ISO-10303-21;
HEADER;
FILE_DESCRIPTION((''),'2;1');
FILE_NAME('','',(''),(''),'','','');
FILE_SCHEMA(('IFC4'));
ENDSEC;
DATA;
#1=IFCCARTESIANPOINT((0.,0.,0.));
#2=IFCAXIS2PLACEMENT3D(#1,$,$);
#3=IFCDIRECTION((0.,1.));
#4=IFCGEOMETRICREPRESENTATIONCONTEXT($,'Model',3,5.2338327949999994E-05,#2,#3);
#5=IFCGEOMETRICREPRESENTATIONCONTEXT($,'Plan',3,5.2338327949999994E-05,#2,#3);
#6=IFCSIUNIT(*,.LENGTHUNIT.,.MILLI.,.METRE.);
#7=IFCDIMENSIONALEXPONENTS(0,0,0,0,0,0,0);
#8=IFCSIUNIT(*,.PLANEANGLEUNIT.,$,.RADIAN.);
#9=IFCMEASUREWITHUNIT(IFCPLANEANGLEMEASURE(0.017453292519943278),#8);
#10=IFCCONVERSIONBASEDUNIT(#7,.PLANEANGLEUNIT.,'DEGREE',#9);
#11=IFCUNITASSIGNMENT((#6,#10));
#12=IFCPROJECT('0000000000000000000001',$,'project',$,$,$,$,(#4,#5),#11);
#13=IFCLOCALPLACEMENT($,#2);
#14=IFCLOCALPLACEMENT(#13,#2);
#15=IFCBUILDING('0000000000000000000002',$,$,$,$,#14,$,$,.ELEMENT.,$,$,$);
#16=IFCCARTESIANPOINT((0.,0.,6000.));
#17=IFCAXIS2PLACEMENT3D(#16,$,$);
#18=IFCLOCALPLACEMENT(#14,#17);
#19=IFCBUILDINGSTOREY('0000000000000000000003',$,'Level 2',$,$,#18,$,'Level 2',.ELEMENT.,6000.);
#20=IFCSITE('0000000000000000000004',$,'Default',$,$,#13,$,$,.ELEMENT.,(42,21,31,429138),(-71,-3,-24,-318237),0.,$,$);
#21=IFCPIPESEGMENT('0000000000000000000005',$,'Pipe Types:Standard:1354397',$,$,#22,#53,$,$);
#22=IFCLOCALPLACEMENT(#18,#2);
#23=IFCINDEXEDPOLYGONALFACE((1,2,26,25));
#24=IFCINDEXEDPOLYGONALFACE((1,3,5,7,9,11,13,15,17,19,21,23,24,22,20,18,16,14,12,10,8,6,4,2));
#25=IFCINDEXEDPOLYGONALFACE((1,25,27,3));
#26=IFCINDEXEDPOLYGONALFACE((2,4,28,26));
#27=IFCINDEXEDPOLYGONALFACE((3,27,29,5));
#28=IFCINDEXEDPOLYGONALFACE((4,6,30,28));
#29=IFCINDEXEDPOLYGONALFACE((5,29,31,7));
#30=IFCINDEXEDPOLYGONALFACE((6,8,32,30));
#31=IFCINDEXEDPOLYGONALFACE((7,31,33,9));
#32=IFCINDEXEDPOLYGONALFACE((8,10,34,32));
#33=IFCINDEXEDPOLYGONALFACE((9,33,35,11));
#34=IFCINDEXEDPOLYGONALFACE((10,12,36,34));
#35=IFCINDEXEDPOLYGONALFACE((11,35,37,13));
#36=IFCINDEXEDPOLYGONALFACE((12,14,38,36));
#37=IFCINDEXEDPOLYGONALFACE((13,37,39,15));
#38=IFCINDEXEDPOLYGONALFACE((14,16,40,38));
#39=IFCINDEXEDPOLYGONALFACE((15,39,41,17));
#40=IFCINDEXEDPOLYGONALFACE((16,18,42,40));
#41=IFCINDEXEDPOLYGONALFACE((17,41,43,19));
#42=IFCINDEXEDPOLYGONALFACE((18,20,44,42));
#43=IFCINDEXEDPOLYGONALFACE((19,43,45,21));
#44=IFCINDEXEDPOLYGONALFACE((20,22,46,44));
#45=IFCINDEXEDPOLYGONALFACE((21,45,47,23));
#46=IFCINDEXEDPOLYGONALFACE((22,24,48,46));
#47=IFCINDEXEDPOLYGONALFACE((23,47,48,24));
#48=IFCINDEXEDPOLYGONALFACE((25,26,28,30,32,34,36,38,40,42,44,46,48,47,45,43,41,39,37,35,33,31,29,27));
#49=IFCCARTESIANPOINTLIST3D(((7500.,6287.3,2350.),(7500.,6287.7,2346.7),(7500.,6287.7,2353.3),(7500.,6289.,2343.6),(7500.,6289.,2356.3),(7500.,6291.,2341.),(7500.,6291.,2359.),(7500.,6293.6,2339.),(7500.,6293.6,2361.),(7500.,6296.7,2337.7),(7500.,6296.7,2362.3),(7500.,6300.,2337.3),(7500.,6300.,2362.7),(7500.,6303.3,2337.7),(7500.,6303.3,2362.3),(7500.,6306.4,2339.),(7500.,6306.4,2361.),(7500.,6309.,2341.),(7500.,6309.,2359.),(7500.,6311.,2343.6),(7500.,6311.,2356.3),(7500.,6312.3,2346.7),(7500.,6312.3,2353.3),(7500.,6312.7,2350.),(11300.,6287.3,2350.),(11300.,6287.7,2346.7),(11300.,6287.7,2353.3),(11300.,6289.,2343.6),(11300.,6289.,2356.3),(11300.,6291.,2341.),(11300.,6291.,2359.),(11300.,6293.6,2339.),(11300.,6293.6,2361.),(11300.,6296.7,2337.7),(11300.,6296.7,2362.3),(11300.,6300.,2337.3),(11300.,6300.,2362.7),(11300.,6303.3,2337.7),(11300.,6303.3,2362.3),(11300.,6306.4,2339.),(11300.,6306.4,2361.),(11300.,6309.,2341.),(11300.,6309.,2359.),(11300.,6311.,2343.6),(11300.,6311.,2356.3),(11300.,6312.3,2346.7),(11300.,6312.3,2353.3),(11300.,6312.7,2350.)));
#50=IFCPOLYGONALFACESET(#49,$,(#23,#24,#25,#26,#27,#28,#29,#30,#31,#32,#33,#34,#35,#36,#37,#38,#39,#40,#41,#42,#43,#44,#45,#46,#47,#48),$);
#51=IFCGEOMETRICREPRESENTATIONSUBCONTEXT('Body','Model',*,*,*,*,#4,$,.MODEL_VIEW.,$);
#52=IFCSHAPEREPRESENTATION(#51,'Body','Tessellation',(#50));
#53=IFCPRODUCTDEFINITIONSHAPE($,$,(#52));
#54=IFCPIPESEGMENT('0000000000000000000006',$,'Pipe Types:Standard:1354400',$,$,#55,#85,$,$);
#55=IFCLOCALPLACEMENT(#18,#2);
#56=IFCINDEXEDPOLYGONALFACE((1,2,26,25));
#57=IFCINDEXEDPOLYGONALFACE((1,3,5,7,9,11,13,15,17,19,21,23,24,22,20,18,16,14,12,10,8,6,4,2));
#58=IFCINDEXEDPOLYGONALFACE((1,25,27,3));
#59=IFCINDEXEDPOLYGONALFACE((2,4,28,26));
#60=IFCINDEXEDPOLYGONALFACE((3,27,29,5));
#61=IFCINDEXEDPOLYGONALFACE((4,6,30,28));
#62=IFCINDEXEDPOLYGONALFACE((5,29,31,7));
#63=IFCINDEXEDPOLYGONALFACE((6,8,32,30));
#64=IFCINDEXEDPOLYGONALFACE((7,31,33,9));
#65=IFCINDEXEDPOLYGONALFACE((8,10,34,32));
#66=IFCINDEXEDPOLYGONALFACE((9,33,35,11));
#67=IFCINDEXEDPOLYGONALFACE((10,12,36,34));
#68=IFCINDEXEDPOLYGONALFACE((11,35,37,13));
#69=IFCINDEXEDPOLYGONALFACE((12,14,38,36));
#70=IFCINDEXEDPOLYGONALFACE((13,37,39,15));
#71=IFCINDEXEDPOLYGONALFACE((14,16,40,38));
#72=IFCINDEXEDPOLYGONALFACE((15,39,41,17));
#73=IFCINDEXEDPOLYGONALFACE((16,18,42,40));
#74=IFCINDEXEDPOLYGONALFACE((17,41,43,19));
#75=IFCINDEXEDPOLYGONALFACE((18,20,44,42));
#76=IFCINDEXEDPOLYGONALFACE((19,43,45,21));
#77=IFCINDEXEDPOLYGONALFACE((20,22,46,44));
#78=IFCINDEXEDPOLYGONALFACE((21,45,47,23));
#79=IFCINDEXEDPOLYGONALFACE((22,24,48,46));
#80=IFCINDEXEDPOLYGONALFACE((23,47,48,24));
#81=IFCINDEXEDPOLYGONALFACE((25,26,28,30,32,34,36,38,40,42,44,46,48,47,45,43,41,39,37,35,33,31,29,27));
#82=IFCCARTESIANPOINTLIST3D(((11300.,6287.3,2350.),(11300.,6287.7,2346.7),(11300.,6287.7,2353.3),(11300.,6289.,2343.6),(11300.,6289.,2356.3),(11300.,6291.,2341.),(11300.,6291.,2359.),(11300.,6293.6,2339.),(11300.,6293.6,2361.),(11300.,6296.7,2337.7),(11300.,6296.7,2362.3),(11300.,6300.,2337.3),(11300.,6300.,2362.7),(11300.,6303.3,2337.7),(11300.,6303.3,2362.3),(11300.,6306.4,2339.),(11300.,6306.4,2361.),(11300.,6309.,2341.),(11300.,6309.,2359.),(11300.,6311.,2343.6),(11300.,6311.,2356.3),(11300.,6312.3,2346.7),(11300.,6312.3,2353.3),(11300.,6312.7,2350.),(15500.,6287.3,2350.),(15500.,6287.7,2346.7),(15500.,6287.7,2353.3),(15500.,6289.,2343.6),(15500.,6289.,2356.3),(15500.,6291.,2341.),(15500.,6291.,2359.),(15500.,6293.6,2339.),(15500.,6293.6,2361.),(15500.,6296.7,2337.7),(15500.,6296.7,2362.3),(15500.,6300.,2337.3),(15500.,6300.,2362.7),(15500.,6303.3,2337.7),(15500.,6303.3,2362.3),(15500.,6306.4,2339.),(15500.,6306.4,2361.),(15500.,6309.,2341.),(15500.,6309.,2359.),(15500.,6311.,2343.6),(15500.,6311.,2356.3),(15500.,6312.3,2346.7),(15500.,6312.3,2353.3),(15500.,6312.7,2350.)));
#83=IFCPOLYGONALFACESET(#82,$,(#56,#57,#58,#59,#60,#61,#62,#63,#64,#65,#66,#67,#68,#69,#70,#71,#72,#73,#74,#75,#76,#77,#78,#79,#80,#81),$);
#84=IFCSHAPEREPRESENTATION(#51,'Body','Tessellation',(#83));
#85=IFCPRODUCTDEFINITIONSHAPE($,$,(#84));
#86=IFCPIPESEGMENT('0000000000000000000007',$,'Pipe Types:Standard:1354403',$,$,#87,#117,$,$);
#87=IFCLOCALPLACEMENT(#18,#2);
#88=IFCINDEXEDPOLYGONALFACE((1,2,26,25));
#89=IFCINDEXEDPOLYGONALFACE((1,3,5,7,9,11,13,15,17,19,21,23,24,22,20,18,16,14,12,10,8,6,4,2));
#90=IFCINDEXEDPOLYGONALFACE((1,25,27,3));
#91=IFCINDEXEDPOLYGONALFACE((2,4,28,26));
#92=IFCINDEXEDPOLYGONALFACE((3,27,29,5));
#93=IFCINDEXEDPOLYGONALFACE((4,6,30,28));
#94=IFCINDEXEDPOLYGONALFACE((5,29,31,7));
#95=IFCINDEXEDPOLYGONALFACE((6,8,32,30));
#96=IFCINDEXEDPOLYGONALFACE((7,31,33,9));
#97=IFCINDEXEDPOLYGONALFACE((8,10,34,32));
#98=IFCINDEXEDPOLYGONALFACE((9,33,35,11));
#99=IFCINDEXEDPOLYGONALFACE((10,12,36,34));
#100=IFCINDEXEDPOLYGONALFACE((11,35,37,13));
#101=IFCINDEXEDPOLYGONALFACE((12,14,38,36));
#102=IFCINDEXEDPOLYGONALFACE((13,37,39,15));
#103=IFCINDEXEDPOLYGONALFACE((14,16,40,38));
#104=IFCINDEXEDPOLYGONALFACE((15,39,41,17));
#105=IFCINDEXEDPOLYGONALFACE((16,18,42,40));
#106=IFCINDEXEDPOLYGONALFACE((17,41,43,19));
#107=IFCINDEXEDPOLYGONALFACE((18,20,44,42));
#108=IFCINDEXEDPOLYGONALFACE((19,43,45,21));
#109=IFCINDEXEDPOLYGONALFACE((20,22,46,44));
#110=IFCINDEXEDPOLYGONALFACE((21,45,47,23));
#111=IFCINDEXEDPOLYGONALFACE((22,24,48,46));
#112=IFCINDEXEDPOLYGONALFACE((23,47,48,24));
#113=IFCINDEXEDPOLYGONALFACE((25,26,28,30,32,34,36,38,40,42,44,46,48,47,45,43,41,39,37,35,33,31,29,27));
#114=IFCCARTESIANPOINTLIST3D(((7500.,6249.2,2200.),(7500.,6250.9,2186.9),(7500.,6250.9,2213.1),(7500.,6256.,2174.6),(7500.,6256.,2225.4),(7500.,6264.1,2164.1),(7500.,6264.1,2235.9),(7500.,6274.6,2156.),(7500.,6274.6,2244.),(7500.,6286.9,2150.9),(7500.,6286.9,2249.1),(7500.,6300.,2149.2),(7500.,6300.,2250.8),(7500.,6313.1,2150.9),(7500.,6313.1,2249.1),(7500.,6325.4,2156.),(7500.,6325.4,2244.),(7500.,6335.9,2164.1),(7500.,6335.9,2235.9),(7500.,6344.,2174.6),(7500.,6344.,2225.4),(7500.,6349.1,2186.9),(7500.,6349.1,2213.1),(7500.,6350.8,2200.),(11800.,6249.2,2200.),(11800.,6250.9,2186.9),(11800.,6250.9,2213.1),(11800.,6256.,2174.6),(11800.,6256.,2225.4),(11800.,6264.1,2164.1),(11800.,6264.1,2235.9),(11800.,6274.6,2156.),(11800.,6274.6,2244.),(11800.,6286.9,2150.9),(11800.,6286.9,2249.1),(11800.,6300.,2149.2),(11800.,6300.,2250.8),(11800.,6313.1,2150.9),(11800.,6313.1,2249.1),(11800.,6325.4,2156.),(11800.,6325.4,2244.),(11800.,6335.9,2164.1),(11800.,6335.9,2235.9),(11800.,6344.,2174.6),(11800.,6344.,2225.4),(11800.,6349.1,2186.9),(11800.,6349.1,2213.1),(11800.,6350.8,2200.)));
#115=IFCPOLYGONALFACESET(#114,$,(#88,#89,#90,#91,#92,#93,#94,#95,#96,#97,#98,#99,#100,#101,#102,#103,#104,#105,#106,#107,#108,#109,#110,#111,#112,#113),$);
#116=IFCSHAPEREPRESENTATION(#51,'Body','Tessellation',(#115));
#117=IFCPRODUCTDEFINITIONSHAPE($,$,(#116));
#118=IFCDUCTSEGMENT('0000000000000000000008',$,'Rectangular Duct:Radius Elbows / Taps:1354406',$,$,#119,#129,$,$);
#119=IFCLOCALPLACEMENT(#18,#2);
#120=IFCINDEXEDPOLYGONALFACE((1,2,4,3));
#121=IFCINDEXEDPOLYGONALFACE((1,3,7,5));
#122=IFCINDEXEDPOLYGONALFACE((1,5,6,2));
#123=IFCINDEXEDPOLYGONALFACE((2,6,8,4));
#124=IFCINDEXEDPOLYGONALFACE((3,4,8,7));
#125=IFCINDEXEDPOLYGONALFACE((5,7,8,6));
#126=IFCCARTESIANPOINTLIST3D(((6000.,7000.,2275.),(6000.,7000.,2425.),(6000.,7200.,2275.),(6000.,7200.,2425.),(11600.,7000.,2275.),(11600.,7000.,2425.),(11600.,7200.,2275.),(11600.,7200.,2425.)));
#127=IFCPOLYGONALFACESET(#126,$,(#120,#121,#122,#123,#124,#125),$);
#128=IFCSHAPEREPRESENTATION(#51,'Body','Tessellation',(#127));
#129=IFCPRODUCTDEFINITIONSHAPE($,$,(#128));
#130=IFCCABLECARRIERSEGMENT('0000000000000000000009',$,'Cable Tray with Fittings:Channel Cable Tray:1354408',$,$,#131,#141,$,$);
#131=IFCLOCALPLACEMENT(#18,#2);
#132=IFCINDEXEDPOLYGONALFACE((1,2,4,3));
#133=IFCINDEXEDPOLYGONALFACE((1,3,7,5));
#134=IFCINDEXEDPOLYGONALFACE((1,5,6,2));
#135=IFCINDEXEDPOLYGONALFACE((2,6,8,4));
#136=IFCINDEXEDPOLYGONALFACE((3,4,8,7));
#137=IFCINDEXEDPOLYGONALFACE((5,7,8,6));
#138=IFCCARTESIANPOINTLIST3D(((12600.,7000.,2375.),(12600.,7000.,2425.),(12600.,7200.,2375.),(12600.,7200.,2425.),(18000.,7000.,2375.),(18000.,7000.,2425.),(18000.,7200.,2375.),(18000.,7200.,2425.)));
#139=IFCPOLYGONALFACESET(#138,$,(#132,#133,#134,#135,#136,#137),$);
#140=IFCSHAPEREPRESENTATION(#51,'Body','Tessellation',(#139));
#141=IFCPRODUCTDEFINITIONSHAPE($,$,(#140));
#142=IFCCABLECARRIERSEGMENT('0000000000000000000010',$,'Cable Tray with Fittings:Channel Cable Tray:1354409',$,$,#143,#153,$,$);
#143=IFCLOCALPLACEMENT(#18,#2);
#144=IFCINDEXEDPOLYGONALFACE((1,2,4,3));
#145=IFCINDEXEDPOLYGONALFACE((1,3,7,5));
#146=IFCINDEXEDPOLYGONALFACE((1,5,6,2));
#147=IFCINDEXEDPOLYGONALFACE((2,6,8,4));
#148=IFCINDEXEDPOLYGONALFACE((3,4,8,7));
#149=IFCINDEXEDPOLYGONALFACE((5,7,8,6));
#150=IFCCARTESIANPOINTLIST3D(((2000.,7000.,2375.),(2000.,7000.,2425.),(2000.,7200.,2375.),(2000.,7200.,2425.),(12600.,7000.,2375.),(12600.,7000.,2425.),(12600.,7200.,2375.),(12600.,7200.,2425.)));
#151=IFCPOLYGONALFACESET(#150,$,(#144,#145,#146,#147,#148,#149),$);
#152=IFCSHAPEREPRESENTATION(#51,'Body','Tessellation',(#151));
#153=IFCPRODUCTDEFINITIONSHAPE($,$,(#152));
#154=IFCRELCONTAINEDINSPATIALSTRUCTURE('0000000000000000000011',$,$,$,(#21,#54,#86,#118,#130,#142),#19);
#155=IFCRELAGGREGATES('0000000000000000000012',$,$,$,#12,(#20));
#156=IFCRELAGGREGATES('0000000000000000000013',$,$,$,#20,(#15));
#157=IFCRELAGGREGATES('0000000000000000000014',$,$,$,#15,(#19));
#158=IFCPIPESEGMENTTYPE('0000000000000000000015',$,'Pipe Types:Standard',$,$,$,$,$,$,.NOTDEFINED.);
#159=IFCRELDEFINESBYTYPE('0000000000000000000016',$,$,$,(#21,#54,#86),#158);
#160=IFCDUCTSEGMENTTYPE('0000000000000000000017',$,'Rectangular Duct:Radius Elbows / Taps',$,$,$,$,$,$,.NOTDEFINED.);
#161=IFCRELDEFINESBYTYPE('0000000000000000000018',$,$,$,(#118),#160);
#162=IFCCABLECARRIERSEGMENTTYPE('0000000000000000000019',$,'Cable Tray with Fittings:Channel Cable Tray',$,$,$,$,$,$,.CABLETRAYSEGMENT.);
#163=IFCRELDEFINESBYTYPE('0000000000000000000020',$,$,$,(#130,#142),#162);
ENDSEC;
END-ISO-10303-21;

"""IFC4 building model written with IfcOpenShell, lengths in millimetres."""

from ifc_helpers import new_model, entity, si_unit, converted_unit, direction, frame, origin, place, context, subcontext, project, spatial, arc, indexed_curve, outline, extrude, type_object, element, save


model = new_model("IFC4")

# Units and contexts
model_context = context("Model", 3, precision=5.2338327949999994e-05, world=origin(), true_north=direction((0.0, 1.0)))
plan_context = context("Plan", 3, precision=5.2338327949999994e-05, world=origin(), true_north=direction((0.0, 1.0)))
body_context = subcontext(model_context, "Body", "Model", "MODEL_VIEW")
ifc_project = project(units=[si_unit("LENGTHUNIT", "METRE", prefix="MILLI"), converted_unit("PLANEANGLEUNIT", "DEGREE", entity("IfcPlaneAngleMeasure", 0.017453292519943278), si_unit("PLANEANGLEUNIT", "RADIAN"), dimensions=[0, 0, 0, 0, 0, 0, 0])], contexts=[model_context, plan_context])

# Site, building, storey
site_placement = place(None, origin())
site = spatial("IfcSite", under=ifc_project, at=site_placement, Name="Default", CompositionType="ELEMENT", RefLatitude=(42, 21, 31, 429138), RefLongitude=(-71, -3, -24, -318237), RefElevation=0.0)
building_placement = place(site_placement, origin())
building = spatial("IfcBuilding", under=site, at=building_placement, CompositionType="ELEMENT")
storey_placement = place(building_placement, frame((0.0, 0.0, 6000.0)))
storey = spatial("IfcBuildingStorey", under=building, at=storey_placement, Name="Level 2", LongName="Level 2", CompositionType="ELEMENT", Elevation=6000.0)

# Pipe segments
pipe_segment_type = type_object("IfcPipeSegmentType", Name="Pipe Types:Standard", PredefinedType="NOTDEFINED")
pipe_segment_1_placement = place(storey_placement, origin())
element("IfcPipeSegment", 1, at=pipe_segment_1_placement, inside=storey, type_object=pipe_segment_type, Name="Pipe Types:Standard:1354397", context=body_context, shape_type="SweptSolid", body=[
    extrude(outline(indexed_curve([(12.7, 0.0), (9.0, 9.0), (0.0, 12.7), (-9.0, 9.0), (-12.7, 0.0), (-9.0, -9.0), (0.0, -12.7), (9.0, -9.0)], segments=[arc(1, 2, 3), arc(3, 4, 5), arc(5, 6, 7), arc(7, 8, 1)], self_intersect=False)), frame((7500.0, 6300.0, 2350.0), z_axis=(1.0, 0.0, 0.0), x_axis=(0.0, 1.0, 0.0)), (0.0, 0.0, 1.0), 3800.0),
])
pipe_segment_2_placement = place(storey_placement, origin())
element("IfcPipeSegment", 2, at=pipe_segment_2_placement, inside=storey, type_object=pipe_segment_type, Name="Pipe Types:Standard:1354400", context=body_context, shape_type="SweptSolid", body=[
    extrude(outline(indexed_curve([(12.7, 0.0), (9.0, 9.0), (0.0, 12.7), (-9.0, 9.0), (-12.7, 0.0), (-9.0, -9.0), (0.0, -12.7), (9.0, -9.0)], segments=[arc(1, 2, 3), arc(3, 4, 5), arc(5, 6, 7), arc(7, 8, 1)], self_intersect=False)), frame((11300.0, 6300.0, 2350.0), z_axis=(1.0, 0.0, 0.0), x_axis=(0.0, -1.0, 0.0)), (0.0, 0.0, 1.0), 4200.0),
])
pipe_segment_3_placement = place(storey_placement, origin())
element("IfcPipeSegment", 3, at=pipe_segment_3_placement, inside=storey, type_object=pipe_segment_type, Name="Pipe Types:Standard:1354403", context=body_context, shape_type="SweptSolid", body=[
    extrude(outline(indexed_curve([(50.8, 0.0), (35.9, 35.9), (0.0, 50.8), (-35.9, 35.9), (-50.8, 0.0), (-35.9, -35.9), (0.0, -50.8), (35.9, -35.9)], segments=[arc(1, 2, 3), arc(3, 4, 5), arc(5, 6, 7), arc(7, 8, 1)], self_intersect=False)), frame((7500.0, 6300.0, 2200.0), z_axis=(1.0, 0.0, 0.0), x_axis=(0.0, 1.0, 0.0)), (0.0, 0.0, 1.0), 4300.0),
])

# Duct segment
duct_segment_type = type_object("IfcDuctSegmentType", Name="Rectangular Duct:Radius Elbows / Taps", PredefinedType="NOTDEFINED")
duct_segment_placement = place(storey_placement, origin())
element("IfcDuctSegment", 4, at=duct_segment_placement, inside=storey, type_object=duct_segment_type, Name="Rectangular Duct:Radius Elbows / Taps:1354406", context=body_context, shape_type="SweptSolid", body=[
    extrude(outline(indexed_curve([(-2800.0, -100.0), (2800.0, -100.0), (2800.0, 100.0), (-2800.0, 100.0), (-2800.0, -100.0)], self_intersect=False)), frame((8800.0, 7100.0, 2275.0), z_axis=(0.0, 0.0, 1.0), x_axis=(-1.0, 0.0, 0.0)), (0.0, 0.0, 1.0), 150.0),
])

# Cable carrier segments
cable_carrier_segment_type = type_object("IfcCableCarrierSegmentType", Name="Cable Tray with Fittings:Channel Cable Tray", PredefinedType="CABLETRAYSEGMENT")
cable_carrier_segment_1_placement = place(storey_placement, origin())
element("IfcCableCarrierSegment", 5, at=cable_carrier_segment_1_placement, inside=storey, type_object=cable_carrier_segment_type, Name="Cable Tray with Fittings:Channel Cable Tray:1354408", context=body_context, shape_type="SweptSolid", body=[
    extrude(outline(indexed_curve([(-2700.0, -100.0), (2700.0, -100.0), (2700.0, 100.0), (-2700.0, 100.0), (-2700.0, -100.0)], self_intersect=False)), frame((15300.0, 7100.0, 2375.0)), (0.0, 0.0, 1.0), 50.0),
])
cable_carrier_segment_2_placement = place(storey_placement, origin())
element("IfcCableCarrierSegment", 6, at=cable_carrier_segment_2_placement, inside=storey, type_object=cable_carrier_segment_type, Name="Cable Tray with Fittings:Channel Cable Tray:1354409", context=body_context, shape_type="SweptSolid", body=[
    extrude(outline(indexed_curve([(-5300.0, -100.0), (5300.0, -100.0), (5300.0, 100.0), (-5300.0, 100.0), (-5300.0, -100.0)], self_intersect=False)), frame((7300.0, 7100.0, 2375.0), z_axis=(0.0, 0.0, 1.0), x_axis=(-1.0, 0.0, 0.0)), (0.0, 0.0, 1.0), 50.0),
])

save(model, "model.ifc")
